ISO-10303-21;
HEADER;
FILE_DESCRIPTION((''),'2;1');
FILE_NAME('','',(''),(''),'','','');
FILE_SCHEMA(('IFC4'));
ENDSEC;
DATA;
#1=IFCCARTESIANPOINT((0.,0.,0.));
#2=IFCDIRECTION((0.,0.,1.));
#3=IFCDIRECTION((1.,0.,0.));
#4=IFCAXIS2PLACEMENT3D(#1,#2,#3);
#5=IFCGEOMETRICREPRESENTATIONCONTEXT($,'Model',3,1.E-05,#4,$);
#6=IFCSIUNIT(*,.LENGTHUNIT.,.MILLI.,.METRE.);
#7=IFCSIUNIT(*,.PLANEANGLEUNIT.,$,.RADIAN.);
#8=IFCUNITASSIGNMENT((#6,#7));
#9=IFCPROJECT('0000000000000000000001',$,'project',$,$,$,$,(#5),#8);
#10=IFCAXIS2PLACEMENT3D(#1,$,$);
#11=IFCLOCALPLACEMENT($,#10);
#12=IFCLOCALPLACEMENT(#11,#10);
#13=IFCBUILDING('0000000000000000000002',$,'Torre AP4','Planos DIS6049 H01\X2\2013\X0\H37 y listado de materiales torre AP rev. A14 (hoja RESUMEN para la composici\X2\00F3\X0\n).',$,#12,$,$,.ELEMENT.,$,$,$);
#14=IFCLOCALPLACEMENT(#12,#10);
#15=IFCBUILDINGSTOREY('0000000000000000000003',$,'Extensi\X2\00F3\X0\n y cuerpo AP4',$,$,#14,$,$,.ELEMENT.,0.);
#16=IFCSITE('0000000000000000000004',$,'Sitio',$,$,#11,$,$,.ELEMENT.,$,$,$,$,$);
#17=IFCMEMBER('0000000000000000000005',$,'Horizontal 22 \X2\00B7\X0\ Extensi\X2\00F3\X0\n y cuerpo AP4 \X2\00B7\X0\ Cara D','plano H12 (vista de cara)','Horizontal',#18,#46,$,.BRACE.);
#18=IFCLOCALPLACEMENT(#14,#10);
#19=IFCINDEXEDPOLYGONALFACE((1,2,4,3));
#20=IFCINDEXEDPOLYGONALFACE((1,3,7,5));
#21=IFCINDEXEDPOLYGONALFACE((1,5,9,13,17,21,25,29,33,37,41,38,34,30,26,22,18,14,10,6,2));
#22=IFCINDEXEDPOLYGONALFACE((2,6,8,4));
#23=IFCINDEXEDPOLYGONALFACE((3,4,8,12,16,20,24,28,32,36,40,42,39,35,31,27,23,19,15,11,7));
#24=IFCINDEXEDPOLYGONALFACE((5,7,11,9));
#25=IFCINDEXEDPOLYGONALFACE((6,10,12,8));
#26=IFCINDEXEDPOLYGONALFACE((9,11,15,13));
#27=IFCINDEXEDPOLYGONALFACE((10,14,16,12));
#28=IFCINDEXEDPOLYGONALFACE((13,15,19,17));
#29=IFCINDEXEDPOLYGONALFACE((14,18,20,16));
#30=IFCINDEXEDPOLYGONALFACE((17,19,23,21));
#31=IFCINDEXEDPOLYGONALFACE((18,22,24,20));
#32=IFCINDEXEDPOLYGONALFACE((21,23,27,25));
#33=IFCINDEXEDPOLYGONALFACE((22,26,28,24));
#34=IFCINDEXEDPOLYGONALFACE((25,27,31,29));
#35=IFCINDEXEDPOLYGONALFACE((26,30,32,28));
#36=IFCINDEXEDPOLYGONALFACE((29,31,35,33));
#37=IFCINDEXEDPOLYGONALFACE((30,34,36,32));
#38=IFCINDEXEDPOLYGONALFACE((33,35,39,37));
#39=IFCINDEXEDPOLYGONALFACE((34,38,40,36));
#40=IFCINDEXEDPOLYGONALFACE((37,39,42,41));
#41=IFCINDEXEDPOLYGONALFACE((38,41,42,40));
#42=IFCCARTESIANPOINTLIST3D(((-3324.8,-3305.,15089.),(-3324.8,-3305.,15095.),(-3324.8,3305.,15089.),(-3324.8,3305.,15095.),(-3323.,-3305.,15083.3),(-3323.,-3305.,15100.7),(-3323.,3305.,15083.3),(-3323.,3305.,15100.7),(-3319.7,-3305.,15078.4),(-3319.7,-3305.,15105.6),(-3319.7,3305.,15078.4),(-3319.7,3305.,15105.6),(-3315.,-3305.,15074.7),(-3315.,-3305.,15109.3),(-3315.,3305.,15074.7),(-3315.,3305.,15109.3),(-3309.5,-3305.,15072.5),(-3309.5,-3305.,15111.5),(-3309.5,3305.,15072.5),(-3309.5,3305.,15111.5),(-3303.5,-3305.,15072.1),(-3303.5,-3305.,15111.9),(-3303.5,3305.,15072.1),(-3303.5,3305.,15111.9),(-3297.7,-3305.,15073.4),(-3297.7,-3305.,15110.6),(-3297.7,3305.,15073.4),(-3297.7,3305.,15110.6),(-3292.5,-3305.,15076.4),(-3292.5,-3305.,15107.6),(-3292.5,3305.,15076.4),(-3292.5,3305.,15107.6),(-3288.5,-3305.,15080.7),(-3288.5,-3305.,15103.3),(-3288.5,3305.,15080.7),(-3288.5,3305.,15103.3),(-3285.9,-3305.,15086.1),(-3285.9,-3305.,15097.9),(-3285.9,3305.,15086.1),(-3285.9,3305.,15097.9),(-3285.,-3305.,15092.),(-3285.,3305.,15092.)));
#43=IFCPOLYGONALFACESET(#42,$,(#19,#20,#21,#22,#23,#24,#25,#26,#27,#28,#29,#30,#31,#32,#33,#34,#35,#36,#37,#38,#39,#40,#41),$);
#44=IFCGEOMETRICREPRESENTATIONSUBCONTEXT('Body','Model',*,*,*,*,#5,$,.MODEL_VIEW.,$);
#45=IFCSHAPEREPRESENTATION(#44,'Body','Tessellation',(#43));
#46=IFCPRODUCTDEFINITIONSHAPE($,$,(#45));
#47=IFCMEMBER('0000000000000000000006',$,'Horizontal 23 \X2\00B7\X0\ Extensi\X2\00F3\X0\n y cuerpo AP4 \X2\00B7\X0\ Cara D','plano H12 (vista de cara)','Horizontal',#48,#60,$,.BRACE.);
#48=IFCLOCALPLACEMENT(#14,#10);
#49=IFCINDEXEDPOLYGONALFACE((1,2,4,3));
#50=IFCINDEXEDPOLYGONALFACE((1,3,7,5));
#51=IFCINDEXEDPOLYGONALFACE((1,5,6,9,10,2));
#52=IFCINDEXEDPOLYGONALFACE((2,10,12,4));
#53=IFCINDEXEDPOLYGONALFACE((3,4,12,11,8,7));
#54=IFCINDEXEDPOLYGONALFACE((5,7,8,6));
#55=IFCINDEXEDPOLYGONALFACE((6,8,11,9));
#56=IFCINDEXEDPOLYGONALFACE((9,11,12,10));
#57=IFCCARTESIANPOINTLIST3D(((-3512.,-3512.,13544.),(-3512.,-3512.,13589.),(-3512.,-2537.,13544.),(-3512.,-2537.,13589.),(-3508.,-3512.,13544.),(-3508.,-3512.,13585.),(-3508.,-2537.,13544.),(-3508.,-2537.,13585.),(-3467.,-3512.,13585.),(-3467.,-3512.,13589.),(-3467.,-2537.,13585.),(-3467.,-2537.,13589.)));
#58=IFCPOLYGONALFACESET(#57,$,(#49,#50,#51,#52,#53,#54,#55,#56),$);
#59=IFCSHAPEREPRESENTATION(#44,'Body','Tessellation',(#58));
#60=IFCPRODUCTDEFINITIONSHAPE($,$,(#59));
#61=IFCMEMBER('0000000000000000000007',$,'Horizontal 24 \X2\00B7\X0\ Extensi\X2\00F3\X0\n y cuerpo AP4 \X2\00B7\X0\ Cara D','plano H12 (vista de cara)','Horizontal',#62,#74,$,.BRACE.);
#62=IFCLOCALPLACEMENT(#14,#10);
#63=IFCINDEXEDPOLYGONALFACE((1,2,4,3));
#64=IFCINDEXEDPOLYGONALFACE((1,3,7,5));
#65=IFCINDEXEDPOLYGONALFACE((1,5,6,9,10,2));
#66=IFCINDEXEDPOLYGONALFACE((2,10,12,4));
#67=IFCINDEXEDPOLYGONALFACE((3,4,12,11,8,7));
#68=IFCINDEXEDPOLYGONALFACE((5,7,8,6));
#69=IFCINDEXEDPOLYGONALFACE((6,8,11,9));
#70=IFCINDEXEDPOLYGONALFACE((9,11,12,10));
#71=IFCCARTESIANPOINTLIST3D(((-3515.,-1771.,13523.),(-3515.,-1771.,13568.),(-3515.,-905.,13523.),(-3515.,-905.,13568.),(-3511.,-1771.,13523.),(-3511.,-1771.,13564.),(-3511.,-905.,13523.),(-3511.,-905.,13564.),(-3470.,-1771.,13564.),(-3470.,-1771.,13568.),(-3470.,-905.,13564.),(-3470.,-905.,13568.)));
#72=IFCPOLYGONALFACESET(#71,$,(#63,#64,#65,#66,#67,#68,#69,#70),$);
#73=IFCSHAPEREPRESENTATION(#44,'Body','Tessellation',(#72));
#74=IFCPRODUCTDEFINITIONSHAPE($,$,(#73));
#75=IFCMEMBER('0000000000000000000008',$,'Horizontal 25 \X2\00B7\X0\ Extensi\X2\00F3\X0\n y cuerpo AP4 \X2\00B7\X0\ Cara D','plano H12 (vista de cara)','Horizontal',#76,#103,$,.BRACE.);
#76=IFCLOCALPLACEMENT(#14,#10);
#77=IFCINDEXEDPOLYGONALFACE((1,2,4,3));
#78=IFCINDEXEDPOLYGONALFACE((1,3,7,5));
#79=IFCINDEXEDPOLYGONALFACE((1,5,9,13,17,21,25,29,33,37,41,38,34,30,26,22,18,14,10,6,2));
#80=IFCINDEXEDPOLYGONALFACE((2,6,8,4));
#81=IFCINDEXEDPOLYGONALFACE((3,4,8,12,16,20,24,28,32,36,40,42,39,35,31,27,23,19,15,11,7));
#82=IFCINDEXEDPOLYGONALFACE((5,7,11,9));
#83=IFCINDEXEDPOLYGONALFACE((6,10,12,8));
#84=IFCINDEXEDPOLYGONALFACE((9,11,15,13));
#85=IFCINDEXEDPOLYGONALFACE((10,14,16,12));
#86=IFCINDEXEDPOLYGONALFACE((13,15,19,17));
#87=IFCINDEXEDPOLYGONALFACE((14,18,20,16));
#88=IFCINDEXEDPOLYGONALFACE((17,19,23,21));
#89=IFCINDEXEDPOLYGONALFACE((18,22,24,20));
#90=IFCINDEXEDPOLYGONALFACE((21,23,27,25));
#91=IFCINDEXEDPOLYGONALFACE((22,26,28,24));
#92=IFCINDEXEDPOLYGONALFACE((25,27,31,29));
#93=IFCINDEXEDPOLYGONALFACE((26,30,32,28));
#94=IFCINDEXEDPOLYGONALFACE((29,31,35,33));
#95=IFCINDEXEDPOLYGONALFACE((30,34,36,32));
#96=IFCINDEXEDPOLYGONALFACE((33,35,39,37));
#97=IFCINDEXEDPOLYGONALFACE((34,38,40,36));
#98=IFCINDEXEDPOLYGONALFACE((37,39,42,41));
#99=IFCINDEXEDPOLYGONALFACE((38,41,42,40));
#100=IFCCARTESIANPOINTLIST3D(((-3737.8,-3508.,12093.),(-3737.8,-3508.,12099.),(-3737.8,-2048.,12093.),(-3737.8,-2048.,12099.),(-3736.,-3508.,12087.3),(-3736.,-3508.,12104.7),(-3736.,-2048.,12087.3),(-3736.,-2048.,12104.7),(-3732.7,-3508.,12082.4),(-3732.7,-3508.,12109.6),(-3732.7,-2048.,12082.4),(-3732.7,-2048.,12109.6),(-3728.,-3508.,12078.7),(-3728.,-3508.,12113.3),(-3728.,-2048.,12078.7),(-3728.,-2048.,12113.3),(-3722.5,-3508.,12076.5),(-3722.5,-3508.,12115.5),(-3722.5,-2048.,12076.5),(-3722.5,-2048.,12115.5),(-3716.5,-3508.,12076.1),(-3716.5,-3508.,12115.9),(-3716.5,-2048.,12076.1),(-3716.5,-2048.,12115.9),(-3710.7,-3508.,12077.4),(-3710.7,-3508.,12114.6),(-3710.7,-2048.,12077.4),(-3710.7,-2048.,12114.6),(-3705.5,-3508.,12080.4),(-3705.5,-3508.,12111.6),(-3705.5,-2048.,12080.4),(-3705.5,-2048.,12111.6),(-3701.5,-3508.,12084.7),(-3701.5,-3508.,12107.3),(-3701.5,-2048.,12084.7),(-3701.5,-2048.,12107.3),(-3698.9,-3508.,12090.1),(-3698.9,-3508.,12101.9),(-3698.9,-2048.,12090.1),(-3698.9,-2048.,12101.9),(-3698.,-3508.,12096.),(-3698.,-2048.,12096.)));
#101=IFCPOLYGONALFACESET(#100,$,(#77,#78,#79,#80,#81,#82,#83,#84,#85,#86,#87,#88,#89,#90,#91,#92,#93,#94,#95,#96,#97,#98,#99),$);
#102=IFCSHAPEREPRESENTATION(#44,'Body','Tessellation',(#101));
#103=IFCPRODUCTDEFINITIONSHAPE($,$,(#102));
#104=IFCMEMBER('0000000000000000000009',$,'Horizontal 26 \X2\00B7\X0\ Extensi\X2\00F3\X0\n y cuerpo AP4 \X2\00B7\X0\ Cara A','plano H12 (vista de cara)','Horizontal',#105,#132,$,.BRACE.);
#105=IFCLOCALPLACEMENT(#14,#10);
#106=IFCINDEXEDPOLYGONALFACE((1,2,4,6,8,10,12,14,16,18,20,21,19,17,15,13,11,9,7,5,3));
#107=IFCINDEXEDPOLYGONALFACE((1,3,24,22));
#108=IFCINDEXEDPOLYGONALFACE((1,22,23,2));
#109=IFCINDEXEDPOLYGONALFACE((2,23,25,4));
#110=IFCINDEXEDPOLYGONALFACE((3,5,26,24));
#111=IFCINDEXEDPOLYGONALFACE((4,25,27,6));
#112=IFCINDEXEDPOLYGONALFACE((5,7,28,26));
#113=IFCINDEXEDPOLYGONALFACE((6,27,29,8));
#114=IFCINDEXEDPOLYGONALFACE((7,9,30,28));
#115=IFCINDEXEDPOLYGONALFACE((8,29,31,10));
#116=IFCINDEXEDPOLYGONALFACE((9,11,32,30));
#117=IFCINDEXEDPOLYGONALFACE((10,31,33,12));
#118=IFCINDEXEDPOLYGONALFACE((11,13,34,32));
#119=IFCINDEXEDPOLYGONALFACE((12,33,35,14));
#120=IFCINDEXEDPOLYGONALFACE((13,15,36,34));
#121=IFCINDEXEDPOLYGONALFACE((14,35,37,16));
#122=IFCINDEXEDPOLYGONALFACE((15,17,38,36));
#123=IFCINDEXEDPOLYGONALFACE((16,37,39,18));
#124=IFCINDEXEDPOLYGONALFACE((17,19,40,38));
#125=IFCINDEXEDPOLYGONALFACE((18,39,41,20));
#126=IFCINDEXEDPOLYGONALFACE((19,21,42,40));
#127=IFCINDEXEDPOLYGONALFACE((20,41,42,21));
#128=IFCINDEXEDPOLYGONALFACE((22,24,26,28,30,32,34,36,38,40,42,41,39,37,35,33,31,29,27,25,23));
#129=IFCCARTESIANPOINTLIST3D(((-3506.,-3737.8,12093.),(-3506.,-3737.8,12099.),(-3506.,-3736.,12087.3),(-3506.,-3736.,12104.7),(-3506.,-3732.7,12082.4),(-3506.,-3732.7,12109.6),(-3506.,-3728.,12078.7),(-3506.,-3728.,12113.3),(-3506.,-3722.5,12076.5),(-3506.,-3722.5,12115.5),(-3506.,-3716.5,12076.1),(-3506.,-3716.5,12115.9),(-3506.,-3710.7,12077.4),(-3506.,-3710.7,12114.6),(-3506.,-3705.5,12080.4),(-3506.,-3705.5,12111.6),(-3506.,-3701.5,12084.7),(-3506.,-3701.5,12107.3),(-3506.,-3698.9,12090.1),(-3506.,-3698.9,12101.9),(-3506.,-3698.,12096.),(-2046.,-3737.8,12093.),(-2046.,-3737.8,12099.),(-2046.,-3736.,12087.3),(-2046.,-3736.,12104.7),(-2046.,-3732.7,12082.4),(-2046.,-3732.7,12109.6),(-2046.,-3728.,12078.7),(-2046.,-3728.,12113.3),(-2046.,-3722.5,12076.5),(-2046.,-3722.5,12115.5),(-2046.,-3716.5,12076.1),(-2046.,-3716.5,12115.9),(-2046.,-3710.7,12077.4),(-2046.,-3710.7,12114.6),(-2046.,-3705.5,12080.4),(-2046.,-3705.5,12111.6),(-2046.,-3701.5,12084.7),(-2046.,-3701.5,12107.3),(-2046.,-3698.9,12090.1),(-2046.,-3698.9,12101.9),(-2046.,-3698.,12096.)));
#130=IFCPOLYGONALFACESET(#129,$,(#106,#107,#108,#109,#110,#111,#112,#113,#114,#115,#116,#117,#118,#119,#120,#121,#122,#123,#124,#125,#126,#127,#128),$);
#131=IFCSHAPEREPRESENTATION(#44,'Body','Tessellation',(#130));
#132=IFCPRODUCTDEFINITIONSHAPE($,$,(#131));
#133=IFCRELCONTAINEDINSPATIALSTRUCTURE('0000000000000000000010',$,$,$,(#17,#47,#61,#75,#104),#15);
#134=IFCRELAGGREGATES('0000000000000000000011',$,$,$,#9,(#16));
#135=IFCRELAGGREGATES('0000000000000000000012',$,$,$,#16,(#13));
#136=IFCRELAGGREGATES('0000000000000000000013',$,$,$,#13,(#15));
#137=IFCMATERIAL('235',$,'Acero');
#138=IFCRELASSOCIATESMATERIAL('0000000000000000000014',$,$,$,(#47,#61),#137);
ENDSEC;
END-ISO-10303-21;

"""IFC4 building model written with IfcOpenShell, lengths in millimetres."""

from ifc_helpers import new_model, si_unit, frame, frame_2d, origin, origin_with_axes, place, context, subcontext, project, spatial, circle, l_section, extrude, material, element, save


model = new_model("IFC4")

# Units and contexts
model_context = context("Model", 3, precision=1e-05, world=origin_with_axes())
body_context = subcontext(model_context, "Body", "Model", "MODEL_VIEW")
ifc_project = project(units=[si_unit("LENGTHUNIT", "METRE", prefix="MILLI"), si_unit("PLANEANGLEUNIT", "RADIAN")], contexts=[model_context])

# Site, building, storey
site_placement = place(None, origin())
site = spatial("IfcSite", under=ifc_project, at=site_placement, Name="Sitio", CompositionType="ELEMENT")
building_placement = place(site_placement, origin())
building = spatial("IfcBuilding", under=site, at=building_placement, Name="Torre AP4", Description="Planos DIS6049 H01–H37 y listado de materiales torre AP rev. A14 (hoja RESUMEN para la composición).", CompositionType="ELEMENT")
storey_placement = place(building_placement, origin())
storey = spatial("IfcBuildingStorey", under=building, at=storey_placement, Name="Extensión y cuerpo AP4", CompositionType="ELEMENT", Elevation=0.0)

# Members
ifc_material_1 = material(Name="235", Category="Acero")
member_1_placement = place(storey_placement, frame((-3305.0, -3305.0, 15092.0), z_axis=(0.0, 1.0, 0.0), x_axis=(1.0, 0.0, 0.0)))
element("IfcMember", 1, at=member_1_placement, inside=storey, Name="Horizontal 22 · Extensión y cuerpo AP4 · Cara D", Description="plano H12 (vista de cara)", ObjectType="Horizontal", PredefinedType="BRACE", context=body_context, shape_type="SweptSolid", body=[
    extrude(circle(Radius=20.0), None, (0.0, 0.0, 1.0), 6610.0),
])
member_2_placement = place(storey_placement, frame((-3512.0, -3512.0, 13589.0), z_axis=(0.0, 1.0, 0.0), x_axis=(1.0, 0.0, 0.0)))
element("IfcMember", 2, at=member_2_placement, inside=storey, material=ifc_material_1, Name="Horizontal 23 · Extensión y cuerpo AP4 · Cara D", Description="plano H12 (vista de cara)", ObjectType="Horizontal", PredefinedType="BRACE", context=body_context, shape_type="SweptSolid", body=[
    extrude(l_section(Depth=45.0, Width=45.0, Thickness=4.0, at=frame_2d((22.5, 22.5))), None, (0.0, 0.0, 1.0), 975.0),
])
member_3_placement = place(storey_placement, frame((-3515.0, -1771.0, 13568.0), z_axis=(0.0, 1.0, 0.0), x_axis=(1.0, 0.0, 0.0)))
element("IfcMember", 3, at=member_3_placement, inside=storey, material=ifc_material_1, Name="Horizontal 24 · Extensión y cuerpo AP4 · Cara D", Description="plano H12 (vista de cara)", ObjectType="Horizontal", PredefinedType="BRACE", context=body_context, shape_type="SweptSolid", body=[
    extrude(l_section(Depth=45.0, Width=45.0, Thickness=4.0, at=frame_2d((22.5, 22.5))), None, (0.0, 0.0, 1.0), 866.0),
])
for number, where, z_axis, x_axis, name in (
    (4, (-3718.0, -3508.0, 12096.0), (0.0, 1.0, 0.0), (1.0, 0.0, 0.0), "Horizontal 25 · Extensión y cuerpo AP4 · Cara D"),
    (5, (-2046.0, -3718.0, 12096.0), (-1.0, 0.0, 0.0), (0.0, 1.0, 0.0), "Horizontal 26 · Extensión y cuerpo AP4 · Cara A"),
):
    element("IfcMember", number, at=place(storey_placement, frame(where, z_axis=z_axis, x_axis=x_axis)), inside=storey, Name=name, Description="plano H12 (vista de cara)", ObjectType="Horizontal", PredefinedType="BRACE", context=body_context, shape_type="SweptSolid", body=[
        extrude(circle(Radius=20.0), None, (0.0, 0.0, 1.0), 1460.0),
    ])

save(model, "model.ifc")
